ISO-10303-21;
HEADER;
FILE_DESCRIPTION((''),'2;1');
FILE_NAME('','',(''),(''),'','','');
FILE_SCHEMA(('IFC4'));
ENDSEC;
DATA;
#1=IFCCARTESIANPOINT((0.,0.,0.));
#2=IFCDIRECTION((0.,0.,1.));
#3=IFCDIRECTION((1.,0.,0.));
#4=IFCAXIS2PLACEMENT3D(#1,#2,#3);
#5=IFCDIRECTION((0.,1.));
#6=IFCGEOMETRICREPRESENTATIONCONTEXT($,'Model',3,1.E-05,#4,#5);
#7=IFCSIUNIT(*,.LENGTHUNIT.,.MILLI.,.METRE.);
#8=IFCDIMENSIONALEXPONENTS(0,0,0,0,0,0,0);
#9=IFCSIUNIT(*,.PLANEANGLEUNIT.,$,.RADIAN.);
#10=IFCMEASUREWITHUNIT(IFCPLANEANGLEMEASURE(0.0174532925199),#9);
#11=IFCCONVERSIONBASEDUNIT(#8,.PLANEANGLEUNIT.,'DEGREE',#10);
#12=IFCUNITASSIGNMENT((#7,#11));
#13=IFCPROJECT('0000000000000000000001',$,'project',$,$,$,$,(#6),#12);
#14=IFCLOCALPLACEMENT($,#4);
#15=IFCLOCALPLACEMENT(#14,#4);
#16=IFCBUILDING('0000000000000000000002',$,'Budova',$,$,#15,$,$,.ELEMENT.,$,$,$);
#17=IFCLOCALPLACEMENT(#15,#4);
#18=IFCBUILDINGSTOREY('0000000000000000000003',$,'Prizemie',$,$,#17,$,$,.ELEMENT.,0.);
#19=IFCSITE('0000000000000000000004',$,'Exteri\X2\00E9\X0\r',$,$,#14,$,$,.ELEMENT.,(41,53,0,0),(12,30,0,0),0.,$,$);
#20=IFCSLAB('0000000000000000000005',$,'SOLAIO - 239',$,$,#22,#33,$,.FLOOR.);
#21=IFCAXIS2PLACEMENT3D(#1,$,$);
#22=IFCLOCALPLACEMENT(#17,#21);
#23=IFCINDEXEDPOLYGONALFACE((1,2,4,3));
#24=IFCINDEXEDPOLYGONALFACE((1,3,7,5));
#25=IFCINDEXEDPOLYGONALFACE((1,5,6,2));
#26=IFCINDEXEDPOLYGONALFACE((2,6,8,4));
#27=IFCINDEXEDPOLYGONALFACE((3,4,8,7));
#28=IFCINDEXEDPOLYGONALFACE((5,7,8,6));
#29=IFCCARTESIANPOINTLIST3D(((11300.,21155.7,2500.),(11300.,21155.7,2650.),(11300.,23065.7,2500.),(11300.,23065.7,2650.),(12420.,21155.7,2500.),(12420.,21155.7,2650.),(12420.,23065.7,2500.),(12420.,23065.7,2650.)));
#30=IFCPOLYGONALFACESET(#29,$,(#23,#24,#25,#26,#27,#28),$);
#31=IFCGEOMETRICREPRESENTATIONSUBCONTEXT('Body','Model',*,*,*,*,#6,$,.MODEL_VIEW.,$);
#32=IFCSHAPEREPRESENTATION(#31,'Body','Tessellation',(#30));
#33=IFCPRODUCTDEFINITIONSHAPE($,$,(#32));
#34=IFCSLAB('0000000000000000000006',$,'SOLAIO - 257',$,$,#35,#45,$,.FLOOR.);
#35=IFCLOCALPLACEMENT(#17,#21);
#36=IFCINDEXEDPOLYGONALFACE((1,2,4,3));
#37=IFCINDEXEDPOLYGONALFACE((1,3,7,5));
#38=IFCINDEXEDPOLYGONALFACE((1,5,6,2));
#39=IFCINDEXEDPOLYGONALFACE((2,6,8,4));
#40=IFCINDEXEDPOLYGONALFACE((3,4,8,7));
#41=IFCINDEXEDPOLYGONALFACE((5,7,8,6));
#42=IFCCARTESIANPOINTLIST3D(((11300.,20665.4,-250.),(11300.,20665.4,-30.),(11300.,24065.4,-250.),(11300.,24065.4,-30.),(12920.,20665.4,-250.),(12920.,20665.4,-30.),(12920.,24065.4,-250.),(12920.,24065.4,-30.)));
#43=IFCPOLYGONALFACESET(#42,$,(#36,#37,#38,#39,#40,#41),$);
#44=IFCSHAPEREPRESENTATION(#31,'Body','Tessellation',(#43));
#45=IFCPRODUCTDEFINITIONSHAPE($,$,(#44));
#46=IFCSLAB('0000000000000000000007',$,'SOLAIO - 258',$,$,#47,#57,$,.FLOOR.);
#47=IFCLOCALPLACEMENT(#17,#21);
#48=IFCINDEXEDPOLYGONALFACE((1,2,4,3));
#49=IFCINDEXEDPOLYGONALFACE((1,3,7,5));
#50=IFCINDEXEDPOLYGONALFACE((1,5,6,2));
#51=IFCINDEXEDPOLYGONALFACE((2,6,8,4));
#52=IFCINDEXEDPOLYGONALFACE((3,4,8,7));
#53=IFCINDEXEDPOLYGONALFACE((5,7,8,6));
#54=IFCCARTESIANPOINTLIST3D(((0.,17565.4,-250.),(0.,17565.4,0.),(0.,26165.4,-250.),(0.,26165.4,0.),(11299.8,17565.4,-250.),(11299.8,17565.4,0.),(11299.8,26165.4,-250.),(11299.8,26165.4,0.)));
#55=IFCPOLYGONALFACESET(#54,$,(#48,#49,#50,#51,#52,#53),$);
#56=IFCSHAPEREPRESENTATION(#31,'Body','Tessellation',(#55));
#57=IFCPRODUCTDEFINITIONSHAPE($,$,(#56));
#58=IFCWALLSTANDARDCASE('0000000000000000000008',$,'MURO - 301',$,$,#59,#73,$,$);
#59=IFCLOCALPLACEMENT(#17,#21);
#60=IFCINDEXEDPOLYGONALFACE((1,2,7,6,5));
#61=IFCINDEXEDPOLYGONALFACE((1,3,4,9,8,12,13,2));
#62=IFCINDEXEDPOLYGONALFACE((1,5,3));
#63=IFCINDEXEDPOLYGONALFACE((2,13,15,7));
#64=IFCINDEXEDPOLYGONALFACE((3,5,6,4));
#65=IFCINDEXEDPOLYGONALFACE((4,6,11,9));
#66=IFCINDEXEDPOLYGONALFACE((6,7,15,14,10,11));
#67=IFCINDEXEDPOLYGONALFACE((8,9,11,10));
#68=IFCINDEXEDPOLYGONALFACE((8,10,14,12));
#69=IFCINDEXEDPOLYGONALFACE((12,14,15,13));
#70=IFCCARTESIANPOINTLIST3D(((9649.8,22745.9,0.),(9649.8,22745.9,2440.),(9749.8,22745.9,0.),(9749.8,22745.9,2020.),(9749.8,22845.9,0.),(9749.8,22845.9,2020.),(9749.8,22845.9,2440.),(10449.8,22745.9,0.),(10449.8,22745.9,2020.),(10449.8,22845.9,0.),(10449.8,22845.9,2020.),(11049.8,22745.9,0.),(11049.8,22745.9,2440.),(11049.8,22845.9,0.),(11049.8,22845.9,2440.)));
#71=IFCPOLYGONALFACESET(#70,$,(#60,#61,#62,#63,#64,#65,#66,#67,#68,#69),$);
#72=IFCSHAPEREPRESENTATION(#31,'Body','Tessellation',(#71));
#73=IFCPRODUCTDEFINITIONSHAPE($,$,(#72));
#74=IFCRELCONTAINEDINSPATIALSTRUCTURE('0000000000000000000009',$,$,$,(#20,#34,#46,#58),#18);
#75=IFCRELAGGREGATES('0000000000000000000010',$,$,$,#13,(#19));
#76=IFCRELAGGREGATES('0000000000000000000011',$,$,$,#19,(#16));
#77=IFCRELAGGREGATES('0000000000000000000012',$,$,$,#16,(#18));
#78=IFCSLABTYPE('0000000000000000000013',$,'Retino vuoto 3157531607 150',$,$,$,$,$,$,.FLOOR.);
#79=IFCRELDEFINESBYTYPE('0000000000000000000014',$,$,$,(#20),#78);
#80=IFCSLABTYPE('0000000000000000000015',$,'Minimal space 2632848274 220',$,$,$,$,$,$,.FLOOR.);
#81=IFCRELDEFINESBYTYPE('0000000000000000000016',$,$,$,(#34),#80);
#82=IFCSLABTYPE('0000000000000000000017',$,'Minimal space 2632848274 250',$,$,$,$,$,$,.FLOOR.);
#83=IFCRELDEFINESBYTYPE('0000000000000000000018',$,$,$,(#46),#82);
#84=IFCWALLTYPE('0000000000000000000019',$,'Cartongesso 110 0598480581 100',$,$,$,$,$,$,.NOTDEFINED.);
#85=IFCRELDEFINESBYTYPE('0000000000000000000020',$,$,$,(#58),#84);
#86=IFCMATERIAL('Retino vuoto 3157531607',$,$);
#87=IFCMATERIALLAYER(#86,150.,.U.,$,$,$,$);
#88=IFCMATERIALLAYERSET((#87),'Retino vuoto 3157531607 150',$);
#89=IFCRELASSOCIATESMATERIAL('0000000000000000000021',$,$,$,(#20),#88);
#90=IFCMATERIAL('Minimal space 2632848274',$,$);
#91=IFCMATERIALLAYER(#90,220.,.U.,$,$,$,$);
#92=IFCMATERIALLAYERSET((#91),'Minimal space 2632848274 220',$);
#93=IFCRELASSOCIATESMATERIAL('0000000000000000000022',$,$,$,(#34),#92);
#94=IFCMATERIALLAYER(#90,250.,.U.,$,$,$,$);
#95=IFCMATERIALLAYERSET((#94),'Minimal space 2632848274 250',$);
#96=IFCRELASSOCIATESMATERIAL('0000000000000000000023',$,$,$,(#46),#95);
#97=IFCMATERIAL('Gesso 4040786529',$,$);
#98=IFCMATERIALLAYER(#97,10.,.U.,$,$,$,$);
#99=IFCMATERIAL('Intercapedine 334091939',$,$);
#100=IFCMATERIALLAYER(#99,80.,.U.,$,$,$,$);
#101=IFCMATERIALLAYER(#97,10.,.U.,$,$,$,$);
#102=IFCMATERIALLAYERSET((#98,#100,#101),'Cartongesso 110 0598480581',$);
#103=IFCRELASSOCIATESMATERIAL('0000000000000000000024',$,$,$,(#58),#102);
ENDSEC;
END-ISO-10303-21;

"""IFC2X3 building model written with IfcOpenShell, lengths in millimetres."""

from ifc_helpers import new_model, entity, si_unit, converted_unit, direction, frame, origin_with_axes, origin_2d_with_axis, place, context, subcontext, project, spatial, polyline, rectangle, outline, extrude, material, layer, layer_set, layer_usage, type_object, element, save


model = new_model("IFC2X3")

# Units and contexts
model_context = context("Model", 3, precision=1e-05, world=origin_with_axes(), true_north=direction((0.0, 1.0)))
body_context = subcontext(model_context, "Body", "Model", "MODEL_VIEW")
ifc_project = project(units=[si_unit("LENGTHUNIT", "METRE", prefix="MILLI"), converted_unit("PLANEANGLEUNIT", "DEGREE", entity("IfcPlaneAngleMeasure", 0.0174532925199), si_unit("PLANEANGLEUNIT", "RADIAN"), dimensions=[0, 0, 0, 0, 0, 0, 0])], contexts=[model_context])

# Site, building, storey
site_placement = place(None, origin_with_axes())
site = spatial("IfcSite", under=ifc_project, at=site_placement, Name="Exteriér", CompositionType="ELEMENT", RefLatitude=(41, 53, 0, 0), RefLongitude=(12, 30, 0, 0), RefElevation=0.0)
building_placement = place(site_placement, origin_with_axes())
building = spatial("IfcBuilding", under=site, at=building_placement, Name="Budova", CompositionType="ELEMENT")
storey_placement = place(building_placement, origin_with_axes())
storey = spatial("IfcBuildingStorey", under=building, at=storey_placement, Name="Prizemie", CompositionType="ELEMENT", Elevation=0.0)

# Slabs
ifc_material_1 = material(Name="Retino vuoto 3157531607")
ifc_layer_1 = layer(ifc_material_1, 150.0, ventilated="UNKNOWN")
ifc_layer_set_1 = layer_set([ifc_layer_1], Name="Retino vuoto 3157531607 150")
ifc_layer_usage_1 = layer_usage(ifc_layer_set_1, "AXIS3", "NEGATIVE", 150.0)
slab_type_1 = type_object("IfcSlabType", Name="Retino vuoto 3157531607 150", PredefinedType="FLOOR")
slab_1_placement = place(storey_placement, frame((12420.0, 21155.7, 2650.0), z_axis=(0.0, 0.0, 1.0), x_axis=(1.0, 0.0, 0.0)))
element("IfcSlab", 1, at=slab_1_placement, inside=storey, type_object=slab_type_1, material=ifc_layer_usage_1, Name="SOLAIO - 239", PredefinedType="FLOOR", context=body_context, shape_type="SweptSolid", body=[
    extrude(outline(polyline([(0.0, 0.0), (0.0, 1910.0), (-1120.0, 1910.0), (-1120.0, 0.0), (0.0, 0.0)])), frame((0.0, 0.0, -150.0), z_axis=(0.0, 0.0, 1.0), x_axis=(1.0, 0.0, 0.0)), (0.0, 0.0, 1.0), 150.0),
])
ifc_material_2 = material(Name="Minimal space 2632848274")
ifc_layer_2 = layer(ifc_material_2, 220.0, ventilated="UNKNOWN")
ifc_layer_set_2 = layer_set([ifc_layer_2], Name="Minimal space 2632848274 220")
ifc_layer_usage_2 = layer_usage(ifc_layer_set_2, "AXIS3", "NEGATIVE", 220.0)
slab_type_2 = type_object("IfcSlabType", Name="Minimal space 2632848274 220", PredefinedType="FLOOR")
slab_2_placement = place(storey_placement, frame((11300.0, 24065.4, -30.0), z_axis=(0.0, 0.0, 1.0), x_axis=(1.0, 0.0, 0.0)))
element("IfcSlab", 2, at=slab_2_placement, inside=storey, type_object=slab_type_2, material=ifc_layer_usage_2, Name="SOLAIO - 257", PredefinedType="FLOOR", context=body_context, shape_type="SweptSolid", body=[
    extrude(outline(polyline([(0.0, 0.0), (0.0, -3400.0), (1620.0, -3400.0), (1620.0, 0.0), (0.0, 0.0)])), frame((0.0, 0.0, -220.0), z_axis=(0.0, 0.0, 1.0), x_axis=(1.0, 0.0, 0.0)), (0.0, 0.0, 1.0), 220.0),
])
ifc_layer_3 = layer(ifc_material_2, 250.0, ventilated="UNKNOWN")
ifc_layer_set_3 = layer_set([ifc_layer_3], Name="Minimal space 2632848274 250")
ifc_layer_usage_3 = layer_usage(ifc_layer_set_3, "AXIS3", "NEGATIVE", 250.0)
slab_type_3 = type_object("IfcSlabType", Name="Minimal space 2632848274 250", PredefinedType="FLOOR")
slab_3_placement = place(storey_placement, frame((0.0, 26165.4, 0.0), z_axis=(0.0, 0.0, 1.0), x_axis=(1.0, 0.0, 0.0)))
element("IfcSlab", 3, at=slab_3_placement, inside=storey, type_object=slab_type_3, material=ifc_layer_usage_3, Name="SOLAIO - 258", PredefinedType="FLOOR", context=body_context, shape_type="SweptSolid", body=[
    extrude(outline(polyline([(0.0, 0.0), (0.0, -8600.0), (11299.8, -8600.0), (11299.8, 0.0), (0.0, 0.0)])), frame((0.0, 0.0, -250.0), z_axis=(0.0, 0.0, 1.0), x_axis=(1.0, 0.0, 0.0)), (0.0, 0.0, 1.0), 250.0),
])

# Wall, opening
ifc_material_3 = material(Name="Gesso 4040786529")
ifc_layer_4 = layer(ifc_material_3, 10.0, ventilated="UNKNOWN")
ifc_material_4 = material(Name="Intercapedine 334091939")
ifc_layer_5 = layer(ifc_material_4, 80.0, ventilated="UNKNOWN")
ifc_layer_6 = layer(ifc_material_3, 10.0, ventilated="UNKNOWN")
ifc_layer_set_4 = layer_set([ifc_layer_4, ifc_layer_5, ifc_layer_6], Name="Cartongesso 110 0598480581")
ifc_layer_usage_4 = layer_usage(ifc_layer_set_4, "AXIS2", "NEGATIVE", 0.0)
wall_type_1 = type_object("IfcWallType", Name="Cartongesso 110 0598480581 100", PredefinedType="NOTDEFINED")
wall_1_placement = place(storey_placement, frame((9649.8, 22845.9, 0.0), z_axis=(0.0, 0.0, 1.0), x_axis=(1.0, 0.0, 0.0)))
wall_1 = element("IfcWallStandardCase", 4, at=wall_1_placement, inside=storey, type_object=wall_type_1, material=ifc_layer_usage_4, Name="MURO - 301", context=body_context, shape_type="SweptSolid", body=[
    extrude(outline(polyline([(0.0, -100.0), (1400.0, -100.0), (1400.0, 0.0), (100.0, 0.0), (0.0, -100.0)])), origin_with_axes(), (0.0, 0.0, 1.0), 2440.0),
])
opening_placement = place(wall_1_placement, frame((450.0, 0.0, 0.0), z_axis=(0.0, 0.0, 1.0), x_axis=(1.0, 0.0, 0.0)))
element("IfcOpeningElement", 5, at=opening_placement, cuts=wall_1, context=body_context, shape_type="SweptSolid", body=[
    extrude(rectangle(XDim=700.0, YDim=2020.0, at=origin_2d_with_axis()), frame((0.0, 100.0, 1010.0), z_axis=(0.0, 1.0, 0.0), x_axis=(-1.0, 0.0, 0.0)), (0.0, 0.0, -1.0), 300.0),
])

save(model, "model.ifc")
